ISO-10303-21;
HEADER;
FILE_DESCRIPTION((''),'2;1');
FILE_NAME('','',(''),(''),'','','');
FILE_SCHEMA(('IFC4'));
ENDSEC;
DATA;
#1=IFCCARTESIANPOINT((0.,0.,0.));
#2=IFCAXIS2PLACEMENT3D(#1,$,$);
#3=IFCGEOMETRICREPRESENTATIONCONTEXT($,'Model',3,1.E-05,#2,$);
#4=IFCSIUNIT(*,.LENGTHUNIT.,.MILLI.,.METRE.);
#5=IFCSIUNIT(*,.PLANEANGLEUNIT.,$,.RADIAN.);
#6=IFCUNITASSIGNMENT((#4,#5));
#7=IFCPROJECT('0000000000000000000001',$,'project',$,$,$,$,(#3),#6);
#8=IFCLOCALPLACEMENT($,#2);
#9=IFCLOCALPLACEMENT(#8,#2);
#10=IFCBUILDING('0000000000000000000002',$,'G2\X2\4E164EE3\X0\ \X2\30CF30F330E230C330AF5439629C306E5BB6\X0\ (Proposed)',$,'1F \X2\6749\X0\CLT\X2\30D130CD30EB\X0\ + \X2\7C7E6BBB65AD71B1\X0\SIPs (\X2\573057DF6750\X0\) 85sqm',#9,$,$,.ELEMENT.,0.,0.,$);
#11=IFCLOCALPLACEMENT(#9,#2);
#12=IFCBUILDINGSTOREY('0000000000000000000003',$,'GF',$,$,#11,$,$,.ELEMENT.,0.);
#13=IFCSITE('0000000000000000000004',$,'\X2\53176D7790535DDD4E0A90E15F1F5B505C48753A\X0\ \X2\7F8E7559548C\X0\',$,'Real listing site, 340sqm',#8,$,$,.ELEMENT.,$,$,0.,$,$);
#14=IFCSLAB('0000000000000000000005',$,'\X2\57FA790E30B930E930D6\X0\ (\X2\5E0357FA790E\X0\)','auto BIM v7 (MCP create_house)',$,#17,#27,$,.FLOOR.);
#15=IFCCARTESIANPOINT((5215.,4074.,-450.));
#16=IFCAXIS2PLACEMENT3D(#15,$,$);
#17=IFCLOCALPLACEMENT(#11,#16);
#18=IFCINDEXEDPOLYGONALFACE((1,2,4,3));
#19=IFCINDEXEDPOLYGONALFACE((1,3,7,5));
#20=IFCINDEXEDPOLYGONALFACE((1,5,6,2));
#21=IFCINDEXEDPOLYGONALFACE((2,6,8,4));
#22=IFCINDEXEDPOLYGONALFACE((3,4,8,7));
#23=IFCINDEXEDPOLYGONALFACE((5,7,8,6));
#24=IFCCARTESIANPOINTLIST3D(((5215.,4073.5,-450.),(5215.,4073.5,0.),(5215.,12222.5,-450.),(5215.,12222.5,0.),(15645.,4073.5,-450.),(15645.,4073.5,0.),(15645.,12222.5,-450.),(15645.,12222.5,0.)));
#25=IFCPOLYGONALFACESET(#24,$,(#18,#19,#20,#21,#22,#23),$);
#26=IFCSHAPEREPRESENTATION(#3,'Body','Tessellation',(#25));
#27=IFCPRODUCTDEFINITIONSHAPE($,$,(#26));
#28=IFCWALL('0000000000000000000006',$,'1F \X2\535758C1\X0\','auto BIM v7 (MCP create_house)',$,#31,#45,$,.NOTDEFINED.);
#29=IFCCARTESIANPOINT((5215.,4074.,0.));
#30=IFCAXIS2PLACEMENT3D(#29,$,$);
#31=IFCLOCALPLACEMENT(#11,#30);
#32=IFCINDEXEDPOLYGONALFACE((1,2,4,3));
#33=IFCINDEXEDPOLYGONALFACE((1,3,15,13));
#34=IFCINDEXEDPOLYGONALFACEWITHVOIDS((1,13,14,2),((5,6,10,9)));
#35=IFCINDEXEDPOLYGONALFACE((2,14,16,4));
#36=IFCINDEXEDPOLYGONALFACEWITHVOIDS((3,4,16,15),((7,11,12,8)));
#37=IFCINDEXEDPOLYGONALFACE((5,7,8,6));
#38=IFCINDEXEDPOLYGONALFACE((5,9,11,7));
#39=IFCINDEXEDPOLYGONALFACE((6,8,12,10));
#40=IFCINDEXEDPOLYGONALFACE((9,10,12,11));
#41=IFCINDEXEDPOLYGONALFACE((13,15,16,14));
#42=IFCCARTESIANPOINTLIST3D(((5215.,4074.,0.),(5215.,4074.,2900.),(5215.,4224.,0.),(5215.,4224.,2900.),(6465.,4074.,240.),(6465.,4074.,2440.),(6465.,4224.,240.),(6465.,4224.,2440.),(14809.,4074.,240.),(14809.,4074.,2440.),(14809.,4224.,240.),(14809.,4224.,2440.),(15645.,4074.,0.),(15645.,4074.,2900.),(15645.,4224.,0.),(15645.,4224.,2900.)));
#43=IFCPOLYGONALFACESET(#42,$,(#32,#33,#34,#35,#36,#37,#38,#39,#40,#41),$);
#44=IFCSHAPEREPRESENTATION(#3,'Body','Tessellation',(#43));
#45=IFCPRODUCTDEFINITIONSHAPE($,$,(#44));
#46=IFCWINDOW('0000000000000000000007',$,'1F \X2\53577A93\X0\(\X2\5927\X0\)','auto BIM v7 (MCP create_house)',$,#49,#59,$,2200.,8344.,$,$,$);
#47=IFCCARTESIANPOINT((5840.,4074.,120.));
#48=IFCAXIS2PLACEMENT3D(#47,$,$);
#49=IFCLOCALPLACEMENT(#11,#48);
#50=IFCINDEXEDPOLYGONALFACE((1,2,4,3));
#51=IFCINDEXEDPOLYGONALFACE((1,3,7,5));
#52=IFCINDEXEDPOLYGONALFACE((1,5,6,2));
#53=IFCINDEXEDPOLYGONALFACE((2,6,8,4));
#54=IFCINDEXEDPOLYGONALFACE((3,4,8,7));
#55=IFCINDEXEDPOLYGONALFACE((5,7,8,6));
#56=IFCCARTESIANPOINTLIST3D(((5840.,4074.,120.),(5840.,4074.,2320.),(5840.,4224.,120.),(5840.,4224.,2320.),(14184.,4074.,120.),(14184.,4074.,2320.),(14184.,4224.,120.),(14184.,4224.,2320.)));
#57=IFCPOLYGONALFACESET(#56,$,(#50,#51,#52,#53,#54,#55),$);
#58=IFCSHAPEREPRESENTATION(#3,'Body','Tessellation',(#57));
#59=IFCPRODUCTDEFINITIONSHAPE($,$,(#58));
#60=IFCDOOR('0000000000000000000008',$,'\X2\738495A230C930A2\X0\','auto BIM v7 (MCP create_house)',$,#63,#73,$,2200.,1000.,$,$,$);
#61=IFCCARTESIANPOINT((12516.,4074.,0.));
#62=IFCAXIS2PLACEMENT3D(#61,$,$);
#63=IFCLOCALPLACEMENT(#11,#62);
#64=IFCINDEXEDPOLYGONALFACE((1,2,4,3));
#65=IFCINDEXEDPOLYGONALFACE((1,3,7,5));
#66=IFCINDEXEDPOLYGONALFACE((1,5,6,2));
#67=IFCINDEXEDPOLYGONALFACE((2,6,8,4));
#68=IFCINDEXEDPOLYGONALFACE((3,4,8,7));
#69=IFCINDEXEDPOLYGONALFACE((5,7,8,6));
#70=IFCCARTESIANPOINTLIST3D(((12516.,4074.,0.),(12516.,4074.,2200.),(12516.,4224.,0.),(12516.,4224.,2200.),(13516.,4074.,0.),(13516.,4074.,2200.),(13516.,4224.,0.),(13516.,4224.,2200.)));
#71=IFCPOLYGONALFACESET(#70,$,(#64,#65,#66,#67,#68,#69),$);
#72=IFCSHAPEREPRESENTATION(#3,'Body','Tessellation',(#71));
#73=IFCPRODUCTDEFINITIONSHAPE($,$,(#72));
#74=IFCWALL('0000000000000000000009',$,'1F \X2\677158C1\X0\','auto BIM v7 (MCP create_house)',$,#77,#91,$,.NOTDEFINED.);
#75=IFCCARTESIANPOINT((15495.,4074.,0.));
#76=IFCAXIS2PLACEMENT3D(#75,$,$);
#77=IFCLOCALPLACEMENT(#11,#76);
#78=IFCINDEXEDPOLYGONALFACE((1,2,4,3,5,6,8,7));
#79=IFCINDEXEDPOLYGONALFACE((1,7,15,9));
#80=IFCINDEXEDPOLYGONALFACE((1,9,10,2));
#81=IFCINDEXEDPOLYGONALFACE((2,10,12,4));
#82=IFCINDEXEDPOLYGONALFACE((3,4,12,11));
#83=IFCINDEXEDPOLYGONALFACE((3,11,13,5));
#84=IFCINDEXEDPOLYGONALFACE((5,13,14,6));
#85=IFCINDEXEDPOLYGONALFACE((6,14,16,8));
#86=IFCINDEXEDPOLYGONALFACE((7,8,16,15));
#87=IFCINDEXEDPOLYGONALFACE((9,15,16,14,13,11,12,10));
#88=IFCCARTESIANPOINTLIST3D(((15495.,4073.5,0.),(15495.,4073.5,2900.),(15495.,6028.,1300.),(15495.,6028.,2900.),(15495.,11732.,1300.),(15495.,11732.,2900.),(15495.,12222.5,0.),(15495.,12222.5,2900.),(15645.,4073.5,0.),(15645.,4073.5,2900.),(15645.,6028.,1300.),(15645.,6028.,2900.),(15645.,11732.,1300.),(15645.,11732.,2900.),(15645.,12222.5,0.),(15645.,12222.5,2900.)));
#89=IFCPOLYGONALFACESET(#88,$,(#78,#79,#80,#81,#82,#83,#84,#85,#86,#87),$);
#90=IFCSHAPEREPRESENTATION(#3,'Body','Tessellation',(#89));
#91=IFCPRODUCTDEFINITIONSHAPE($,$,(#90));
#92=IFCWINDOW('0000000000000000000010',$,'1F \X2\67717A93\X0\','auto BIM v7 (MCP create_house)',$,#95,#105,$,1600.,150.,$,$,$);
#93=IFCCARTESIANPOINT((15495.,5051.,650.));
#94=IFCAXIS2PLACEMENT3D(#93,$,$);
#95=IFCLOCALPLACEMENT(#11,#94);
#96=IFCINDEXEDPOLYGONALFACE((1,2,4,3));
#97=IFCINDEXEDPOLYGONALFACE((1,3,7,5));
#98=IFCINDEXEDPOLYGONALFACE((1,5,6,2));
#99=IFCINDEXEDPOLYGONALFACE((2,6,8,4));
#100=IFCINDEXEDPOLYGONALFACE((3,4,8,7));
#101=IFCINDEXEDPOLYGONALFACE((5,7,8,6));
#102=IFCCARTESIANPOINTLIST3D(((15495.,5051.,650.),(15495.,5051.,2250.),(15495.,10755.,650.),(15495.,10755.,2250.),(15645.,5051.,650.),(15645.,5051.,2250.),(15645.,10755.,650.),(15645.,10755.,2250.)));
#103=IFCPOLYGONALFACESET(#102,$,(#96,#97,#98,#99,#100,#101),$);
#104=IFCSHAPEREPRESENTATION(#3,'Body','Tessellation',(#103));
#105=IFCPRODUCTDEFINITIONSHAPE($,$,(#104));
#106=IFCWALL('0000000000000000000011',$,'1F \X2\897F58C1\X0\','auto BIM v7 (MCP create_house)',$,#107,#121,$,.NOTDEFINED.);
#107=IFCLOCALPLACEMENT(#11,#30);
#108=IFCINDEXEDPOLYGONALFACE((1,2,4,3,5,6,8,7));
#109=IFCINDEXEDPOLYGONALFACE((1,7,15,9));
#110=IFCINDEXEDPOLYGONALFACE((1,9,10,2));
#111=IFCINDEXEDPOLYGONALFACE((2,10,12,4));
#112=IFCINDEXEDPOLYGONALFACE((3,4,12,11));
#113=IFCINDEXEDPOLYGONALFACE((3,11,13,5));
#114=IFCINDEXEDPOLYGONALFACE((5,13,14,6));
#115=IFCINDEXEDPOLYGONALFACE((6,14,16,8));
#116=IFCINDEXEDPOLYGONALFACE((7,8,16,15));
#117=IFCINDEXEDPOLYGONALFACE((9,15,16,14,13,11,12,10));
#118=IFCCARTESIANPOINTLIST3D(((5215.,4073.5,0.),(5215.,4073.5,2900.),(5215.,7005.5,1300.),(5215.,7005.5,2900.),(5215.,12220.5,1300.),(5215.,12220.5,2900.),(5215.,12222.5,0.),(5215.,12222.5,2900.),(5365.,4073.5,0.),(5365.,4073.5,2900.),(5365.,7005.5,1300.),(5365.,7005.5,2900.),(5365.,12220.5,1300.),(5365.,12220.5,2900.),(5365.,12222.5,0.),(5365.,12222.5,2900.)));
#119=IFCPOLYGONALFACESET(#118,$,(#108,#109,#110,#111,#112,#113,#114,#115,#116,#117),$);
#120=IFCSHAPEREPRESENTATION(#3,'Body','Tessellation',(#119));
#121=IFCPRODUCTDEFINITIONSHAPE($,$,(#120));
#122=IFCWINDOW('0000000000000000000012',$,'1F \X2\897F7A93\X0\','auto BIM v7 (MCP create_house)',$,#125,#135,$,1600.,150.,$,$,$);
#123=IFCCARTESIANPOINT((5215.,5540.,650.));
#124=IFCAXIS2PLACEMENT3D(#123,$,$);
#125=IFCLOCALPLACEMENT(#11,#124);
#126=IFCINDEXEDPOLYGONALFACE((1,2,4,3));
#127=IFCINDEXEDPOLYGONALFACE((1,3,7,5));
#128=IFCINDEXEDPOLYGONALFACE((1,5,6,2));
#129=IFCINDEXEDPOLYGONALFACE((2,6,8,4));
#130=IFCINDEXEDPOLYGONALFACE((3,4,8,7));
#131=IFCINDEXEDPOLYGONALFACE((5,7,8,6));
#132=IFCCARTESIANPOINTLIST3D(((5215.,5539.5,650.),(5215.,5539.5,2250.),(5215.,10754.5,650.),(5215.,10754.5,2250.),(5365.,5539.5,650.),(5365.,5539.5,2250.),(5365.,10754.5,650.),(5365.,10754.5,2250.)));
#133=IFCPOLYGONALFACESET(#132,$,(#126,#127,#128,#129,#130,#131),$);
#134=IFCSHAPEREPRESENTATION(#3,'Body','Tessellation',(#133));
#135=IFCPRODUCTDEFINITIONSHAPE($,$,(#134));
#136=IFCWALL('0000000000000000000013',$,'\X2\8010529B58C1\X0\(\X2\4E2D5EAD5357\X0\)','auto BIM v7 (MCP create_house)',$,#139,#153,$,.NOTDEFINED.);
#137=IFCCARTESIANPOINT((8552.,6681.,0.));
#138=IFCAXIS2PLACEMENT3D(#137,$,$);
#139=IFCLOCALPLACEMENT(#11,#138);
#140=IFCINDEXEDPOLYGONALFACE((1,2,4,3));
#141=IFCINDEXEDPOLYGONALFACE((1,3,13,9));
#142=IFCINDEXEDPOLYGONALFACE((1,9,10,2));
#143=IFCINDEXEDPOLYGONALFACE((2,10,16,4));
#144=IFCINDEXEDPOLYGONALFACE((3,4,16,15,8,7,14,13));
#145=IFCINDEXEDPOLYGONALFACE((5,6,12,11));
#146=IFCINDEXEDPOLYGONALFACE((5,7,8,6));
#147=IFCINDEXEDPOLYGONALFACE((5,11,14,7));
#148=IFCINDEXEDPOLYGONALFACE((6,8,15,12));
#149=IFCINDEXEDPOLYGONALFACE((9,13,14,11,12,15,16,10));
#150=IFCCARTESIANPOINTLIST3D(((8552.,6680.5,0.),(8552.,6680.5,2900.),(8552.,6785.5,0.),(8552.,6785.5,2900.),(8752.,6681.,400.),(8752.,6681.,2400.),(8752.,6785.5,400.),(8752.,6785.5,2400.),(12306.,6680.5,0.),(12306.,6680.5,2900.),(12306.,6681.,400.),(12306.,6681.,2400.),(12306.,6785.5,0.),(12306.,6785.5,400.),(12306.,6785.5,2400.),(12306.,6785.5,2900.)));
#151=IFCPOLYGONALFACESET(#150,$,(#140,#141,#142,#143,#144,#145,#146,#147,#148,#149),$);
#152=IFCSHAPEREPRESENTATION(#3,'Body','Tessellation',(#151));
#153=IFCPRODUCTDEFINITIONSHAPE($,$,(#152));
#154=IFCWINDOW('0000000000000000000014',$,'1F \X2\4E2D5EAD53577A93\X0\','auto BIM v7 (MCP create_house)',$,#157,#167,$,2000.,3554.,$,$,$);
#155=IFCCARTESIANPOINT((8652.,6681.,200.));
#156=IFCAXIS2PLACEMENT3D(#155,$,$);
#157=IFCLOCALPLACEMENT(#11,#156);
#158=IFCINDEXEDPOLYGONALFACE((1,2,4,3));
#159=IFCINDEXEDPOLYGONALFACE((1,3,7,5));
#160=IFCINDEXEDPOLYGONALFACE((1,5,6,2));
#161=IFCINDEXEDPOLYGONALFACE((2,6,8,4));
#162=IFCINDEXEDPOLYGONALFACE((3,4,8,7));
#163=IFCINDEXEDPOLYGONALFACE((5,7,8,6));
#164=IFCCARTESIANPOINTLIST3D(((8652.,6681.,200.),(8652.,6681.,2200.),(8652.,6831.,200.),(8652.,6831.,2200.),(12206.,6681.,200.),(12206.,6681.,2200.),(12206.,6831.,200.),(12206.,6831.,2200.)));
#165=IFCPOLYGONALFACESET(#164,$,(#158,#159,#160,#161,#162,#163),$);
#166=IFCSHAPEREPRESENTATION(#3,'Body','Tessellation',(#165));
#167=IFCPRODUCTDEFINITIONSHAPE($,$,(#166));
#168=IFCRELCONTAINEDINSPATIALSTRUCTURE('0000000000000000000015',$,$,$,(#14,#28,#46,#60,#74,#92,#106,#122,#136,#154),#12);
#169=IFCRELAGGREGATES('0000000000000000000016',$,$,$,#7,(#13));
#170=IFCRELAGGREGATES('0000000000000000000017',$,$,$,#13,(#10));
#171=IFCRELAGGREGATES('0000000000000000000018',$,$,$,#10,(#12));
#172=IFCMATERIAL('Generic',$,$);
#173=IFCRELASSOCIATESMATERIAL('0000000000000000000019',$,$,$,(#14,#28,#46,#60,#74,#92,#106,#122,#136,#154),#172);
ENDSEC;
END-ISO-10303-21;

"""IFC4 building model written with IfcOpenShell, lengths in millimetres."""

from ifc_helpers import new_model, si_unit, frame, frame_2d, origin, place, context, project, spatial, rectangle, extrude, material, element, fill, save


model = new_model("IFC4")

# Units and contexts
model_context = context("Model", 3, precision=1e-05, world=origin())
ifc_project = project(units=[si_unit("LENGTHUNIT", "METRE", prefix="MILLI"), si_unit("PLANEANGLEUNIT", "RADIAN")], contexts=[model_context])

# Site, building, storey
site_placement = place(None, origin())
site = spatial("IfcSite", under=ifc_project, at=site_placement, Name="北海道川上郡弟子屈町 美留和", ObjectType="Real listing site, 340sqm", CompositionType="ELEMENT", RefElevation=0.0)
building_placement = place(site_placement, origin())
building = spatial("IfcBuilding", under=site, at=building_placement, Name="G2世代 ハンモック吹抜の家 (Proposed)", ObjectType="1F 杉CLTパネル + 籾殻断熱SIPs (地域材) 85sqm", CompositionType="ELEMENT", ElevationOfRefHeight=0.0, ElevationOfTerrain=0.0)
storey_placement = place(building_placement, origin())
storey = spatial("IfcBuildingStorey", under=building, at=storey_placement, Name="GF", CompositionType="ELEMENT", Elevation=0.0)

# Slab
ifc_material = material(Name="Generic")
slab_1_placement = place(storey_placement, frame((5215.0, 4074.0, -450.0)))
element("IfcSlab", 1, at=slab_1_placement, inside=storey, material=ifc_material, Name="基礎スラブ (布基礎)", Description="auto BIM v7 (MCP create_house)", PredefinedType="FLOOR", context=model_context, shape_type="SweptSolid", body=[
    extrude(rectangle(XDim=10430.0, YDim=8149.0, at=frame_2d((5215.0, 4074.0))), frame((5215.0, 4074.0, -450.0)), (0.0, 0.0, 1.0), 450.0),
])

# Wall, openings, window, door
wall_1_placement = place(storey_placement, frame((5215.0, 4074.0, 0.0)))
wall_1 = element("IfcWall", 2, at=wall_1_placement, inside=storey, material=ifc_material, Name="1F 南壁", Description="auto BIM v7 (MCP create_house)", PredefinedType="NOTDEFINED", context=model_context, shape_type="SweptSolid", body=[
    extrude(rectangle(XDim=10430.0, YDim=150.0, at=frame_2d((5215.0, 75.0))), frame((5215.0, 4074.0, 0.0)), (0.0, 0.0, 1.0), 2900.0),
])
opening_1_placement = place(storey_placement, frame((5840.0, 4074.0, 120.0)))
opening_1 = element("IfcOpeningElement", 3, at=opening_1_placement, cuts=wall_1, PredefinedType="NOTDEFINED", context=model_context, shape_type="SweptSolid", body=[
    extrude(rectangle(XDim=8344.0, YDim=150.0, at=frame_2d((4172.0, 75.0))), frame((5840.0, 4074.0, 120.0)), (0.0, 0.0, 1.0), 2200.0),
])
opening_2_placement = place(storey_placement, frame((12516.0, 4074.0, 0.0)))
opening_2 = element("IfcOpeningElement", 4, at=opening_2_placement, cuts=wall_1, PredefinedType="NOTDEFINED", context=model_context, shape_type="SweptSolid", body=[
    extrude(rectangle(XDim=1000.0, YDim=150.0, at=frame_2d((500.0, 75.0))), frame((12516.0, 4074.0, 0.0)), (0.0, 0.0, 1.0), 2200.0),
])
window_1_placement = place(storey_placement, frame((5840.0, 4074.0, 120.0)))
window_1 = element("IfcWindow", 5, at=window_1_placement, inside=storey, material=ifc_material, Name="1F 南窓(大)", Description="auto BIM v7 (MCP create_house)", OverallHeight=2200.0, OverallWidth=8344.0, context=model_context, shape_type="SweptSolid", body=[
    extrude(rectangle(XDim=8344.0, YDim=150.0, at=frame_2d((4172.0, 75.0))), frame((5840.0, 4074.0, 120.0)), (0.0, 0.0, 1.0), 2200.0),
])
fill(opening_1, window_1)
door_placement = place(storey_placement, frame((12516.0, 4074.0, 0.0)))
door = element("IfcDoor", 6, at=door_placement, inside=storey, material=ifc_material, Name="玄関ドア", Description="auto BIM v7 (MCP create_house)", OverallHeight=2200.0, OverallWidth=1000.0, context=model_context, shape_type="SweptSolid", body=[
    extrude(rectangle(XDim=1000.0, YDim=150.0, at=frame_2d((500.0, 75.0))), frame((12516.0, 4074.0, 0.0)), (0.0, 0.0, 1.0), 2200.0),
])
fill(opening_2, door)

# Walls, openings, windows
wall_2_placement = place(storey_placement, frame((15495.0, 4074.0, 0.0)))
wall_2 = element("IfcWall", 7, at=wall_2_placement, inside=storey, material=ifc_material, Name="1F 東壁", Description="auto BIM v7 (MCP create_house)", PredefinedType="NOTDEFINED", context=model_context, shape_type="SweptSolid", body=[
    extrude(rectangle(XDim=150.0, YDim=8149.0, at=frame_2d((75.0, 4074.0))), frame((15495.0, 4074.0, 0.0)), (0.0, 0.0, 1.0), 2900.0),
])
opening_3_placement = place(storey_placement, frame((15495.0, 5051.0, 650.0)))
opening_3 = element("IfcOpeningElement", 8, at=opening_3_placement, cuts=wall_2, PredefinedType="NOTDEFINED", context=model_context, shape_type="SweptSolid", body=[
    extrude(rectangle(XDim=150.0, YDim=5704.0, at=frame_2d((75.0, 2852.0))), frame((15495.0, 5051.0, 650.0)), (0.0, 0.0, 1.0), 1600.0),
])
window_2_placement = place(storey_placement, frame((15495.0, 5051.0, 650.0)))
window_2 = element("IfcWindow", 9, at=window_2_placement, inside=storey, material=ifc_material, Name="1F 東窓", Description="auto BIM v7 (MCP create_house)", OverallHeight=1600.0, OverallWidth=150.0, context=model_context, shape_type="SweptSolid", body=[
    extrude(rectangle(XDim=150.0, YDim=5704.0, at=frame_2d((75.0, 2852.0))), frame((15495.0, 5051.0, 650.0)), (0.0, 0.0, 1.0), 1600.0),
])
fill(opening_3, window_2)
wall_3_placement = place(storey_placement, frame((5215.0, 4074.0, 0.0)))
wall_3 = element("IfcWall", 10, at=wall_3_placement, inside=storey, material=ifc_material, Name="1F 西壁", Description="auto BIM v7 (MCP create_house)", PredefinedType="NOTDEFINED", context=model_context, shape_type="SweptSolid", body=[
    extrude(rectangle(XDim=150.0, YDim=8149.0, at=frame_2d((75.0, 4074.0))), frame((5215.0, 4074.0, 0.0)), (0.0, 0.0, 1.0), 2900.0),
])
opening_4_placement = place(storey_placement, frame((5215.0, 5540.0, 650.0)))
opening_4 = element("IfcOpeningElement", 11, at=opening_4_placement, cuts=wall_3, PredefinedType="NOTDEFINED", context=model_context, shape_type="SweptSolid", body=[
    extrude(rectangle(XDim=150.0, YDim=5215.0, at=frame_2d((75.0, 2607.0))), frame((5215.0, 5540.0, 650.0)), (0.0, 0.0, 1.0), 1600.0),
])
window_3_placement = place(storey_placement, frame((5215.0, 5540.0, 650.0)))
window_3 = element("IfcWindow", 12, at=window_3_placement, inside=storey, material=ifc_material, Name="1F 西窓", Description="auto BIM v7 (MCP create_house)", OverallHeight=1600.0, OverallWidth=150.0, context=model_context, shape_type="SweptSolid", body=[
    extrude(rectangle(XDim=150.0, YDim=5215.0, at=frame_2d((75.0, 2607.0))), frame((5215.0, 5540.0, 650.0)), (0.0, 0.0, 1.0), 1600.0),
])
fill(opening_4, window_3)
wall_4_placement = place(storey_placement, frame((8552.0, 6681.0, 0.0)))
wall_4 = element("IfcWall", 13, at=wall_4_placement, inside=storey, material=ifc_material, Name="耐力壁(中庭南)", Description="auto BIM v7 (MCP create_house)", PredefinedType="NOTDEFINED", context=model_context, shape_type="SweptSolid", body=[
    extrude(rectangle(XDim=3754.0, YDim=105.0, at=frame_2d((1877.0, 52.0))), frame((8552.0, 6681.0, 0.0)), (0.0, 0.0, 1.0), 2900.0),
])
opening_5_placement = place(storey_placement, frame((8652.0, 6681.0, 200.0)))
opening_5 = element("IfcOpeningElement", 14, at=opening_5_placement, cuts=wall_4, PredefinedType="NOTDEFINED", context=model_context, shape_type="SweptSolid", body=[
    extrude(rectangle(XDim=3554.0, YDim=150.0, at=frame_2d((1777.0, 75.0))), frame((8652.0, 6681.0, 200.0)), (0.0, 0.0, 1.0), 2000.0),
])
window_4_placement = place(storey_placement, frame((8652.0, 6681.0, 200.0)))
window_4 = element("IfcWindow", 15, at=window_4_placement, inside=storey, material=ifc_material, Name="1F 中庭南窓", Description="auto BIM v7 (MCP create_house)", OverallHeight=2000.0, OverallWidth=3554.0, context=model_context, shape_type="SweptSolid", body=[
    extrude(rectangle(XDim=3554.0, YDim=150.0, at=frame_2d((1777.0, 75.0))), frame((8652.0, 6681.0, 200.0)), (0.0, 0.0, 1.0), 2000.0),
])
fill(opening_5, window_4)

save(model, "model.ifc")
